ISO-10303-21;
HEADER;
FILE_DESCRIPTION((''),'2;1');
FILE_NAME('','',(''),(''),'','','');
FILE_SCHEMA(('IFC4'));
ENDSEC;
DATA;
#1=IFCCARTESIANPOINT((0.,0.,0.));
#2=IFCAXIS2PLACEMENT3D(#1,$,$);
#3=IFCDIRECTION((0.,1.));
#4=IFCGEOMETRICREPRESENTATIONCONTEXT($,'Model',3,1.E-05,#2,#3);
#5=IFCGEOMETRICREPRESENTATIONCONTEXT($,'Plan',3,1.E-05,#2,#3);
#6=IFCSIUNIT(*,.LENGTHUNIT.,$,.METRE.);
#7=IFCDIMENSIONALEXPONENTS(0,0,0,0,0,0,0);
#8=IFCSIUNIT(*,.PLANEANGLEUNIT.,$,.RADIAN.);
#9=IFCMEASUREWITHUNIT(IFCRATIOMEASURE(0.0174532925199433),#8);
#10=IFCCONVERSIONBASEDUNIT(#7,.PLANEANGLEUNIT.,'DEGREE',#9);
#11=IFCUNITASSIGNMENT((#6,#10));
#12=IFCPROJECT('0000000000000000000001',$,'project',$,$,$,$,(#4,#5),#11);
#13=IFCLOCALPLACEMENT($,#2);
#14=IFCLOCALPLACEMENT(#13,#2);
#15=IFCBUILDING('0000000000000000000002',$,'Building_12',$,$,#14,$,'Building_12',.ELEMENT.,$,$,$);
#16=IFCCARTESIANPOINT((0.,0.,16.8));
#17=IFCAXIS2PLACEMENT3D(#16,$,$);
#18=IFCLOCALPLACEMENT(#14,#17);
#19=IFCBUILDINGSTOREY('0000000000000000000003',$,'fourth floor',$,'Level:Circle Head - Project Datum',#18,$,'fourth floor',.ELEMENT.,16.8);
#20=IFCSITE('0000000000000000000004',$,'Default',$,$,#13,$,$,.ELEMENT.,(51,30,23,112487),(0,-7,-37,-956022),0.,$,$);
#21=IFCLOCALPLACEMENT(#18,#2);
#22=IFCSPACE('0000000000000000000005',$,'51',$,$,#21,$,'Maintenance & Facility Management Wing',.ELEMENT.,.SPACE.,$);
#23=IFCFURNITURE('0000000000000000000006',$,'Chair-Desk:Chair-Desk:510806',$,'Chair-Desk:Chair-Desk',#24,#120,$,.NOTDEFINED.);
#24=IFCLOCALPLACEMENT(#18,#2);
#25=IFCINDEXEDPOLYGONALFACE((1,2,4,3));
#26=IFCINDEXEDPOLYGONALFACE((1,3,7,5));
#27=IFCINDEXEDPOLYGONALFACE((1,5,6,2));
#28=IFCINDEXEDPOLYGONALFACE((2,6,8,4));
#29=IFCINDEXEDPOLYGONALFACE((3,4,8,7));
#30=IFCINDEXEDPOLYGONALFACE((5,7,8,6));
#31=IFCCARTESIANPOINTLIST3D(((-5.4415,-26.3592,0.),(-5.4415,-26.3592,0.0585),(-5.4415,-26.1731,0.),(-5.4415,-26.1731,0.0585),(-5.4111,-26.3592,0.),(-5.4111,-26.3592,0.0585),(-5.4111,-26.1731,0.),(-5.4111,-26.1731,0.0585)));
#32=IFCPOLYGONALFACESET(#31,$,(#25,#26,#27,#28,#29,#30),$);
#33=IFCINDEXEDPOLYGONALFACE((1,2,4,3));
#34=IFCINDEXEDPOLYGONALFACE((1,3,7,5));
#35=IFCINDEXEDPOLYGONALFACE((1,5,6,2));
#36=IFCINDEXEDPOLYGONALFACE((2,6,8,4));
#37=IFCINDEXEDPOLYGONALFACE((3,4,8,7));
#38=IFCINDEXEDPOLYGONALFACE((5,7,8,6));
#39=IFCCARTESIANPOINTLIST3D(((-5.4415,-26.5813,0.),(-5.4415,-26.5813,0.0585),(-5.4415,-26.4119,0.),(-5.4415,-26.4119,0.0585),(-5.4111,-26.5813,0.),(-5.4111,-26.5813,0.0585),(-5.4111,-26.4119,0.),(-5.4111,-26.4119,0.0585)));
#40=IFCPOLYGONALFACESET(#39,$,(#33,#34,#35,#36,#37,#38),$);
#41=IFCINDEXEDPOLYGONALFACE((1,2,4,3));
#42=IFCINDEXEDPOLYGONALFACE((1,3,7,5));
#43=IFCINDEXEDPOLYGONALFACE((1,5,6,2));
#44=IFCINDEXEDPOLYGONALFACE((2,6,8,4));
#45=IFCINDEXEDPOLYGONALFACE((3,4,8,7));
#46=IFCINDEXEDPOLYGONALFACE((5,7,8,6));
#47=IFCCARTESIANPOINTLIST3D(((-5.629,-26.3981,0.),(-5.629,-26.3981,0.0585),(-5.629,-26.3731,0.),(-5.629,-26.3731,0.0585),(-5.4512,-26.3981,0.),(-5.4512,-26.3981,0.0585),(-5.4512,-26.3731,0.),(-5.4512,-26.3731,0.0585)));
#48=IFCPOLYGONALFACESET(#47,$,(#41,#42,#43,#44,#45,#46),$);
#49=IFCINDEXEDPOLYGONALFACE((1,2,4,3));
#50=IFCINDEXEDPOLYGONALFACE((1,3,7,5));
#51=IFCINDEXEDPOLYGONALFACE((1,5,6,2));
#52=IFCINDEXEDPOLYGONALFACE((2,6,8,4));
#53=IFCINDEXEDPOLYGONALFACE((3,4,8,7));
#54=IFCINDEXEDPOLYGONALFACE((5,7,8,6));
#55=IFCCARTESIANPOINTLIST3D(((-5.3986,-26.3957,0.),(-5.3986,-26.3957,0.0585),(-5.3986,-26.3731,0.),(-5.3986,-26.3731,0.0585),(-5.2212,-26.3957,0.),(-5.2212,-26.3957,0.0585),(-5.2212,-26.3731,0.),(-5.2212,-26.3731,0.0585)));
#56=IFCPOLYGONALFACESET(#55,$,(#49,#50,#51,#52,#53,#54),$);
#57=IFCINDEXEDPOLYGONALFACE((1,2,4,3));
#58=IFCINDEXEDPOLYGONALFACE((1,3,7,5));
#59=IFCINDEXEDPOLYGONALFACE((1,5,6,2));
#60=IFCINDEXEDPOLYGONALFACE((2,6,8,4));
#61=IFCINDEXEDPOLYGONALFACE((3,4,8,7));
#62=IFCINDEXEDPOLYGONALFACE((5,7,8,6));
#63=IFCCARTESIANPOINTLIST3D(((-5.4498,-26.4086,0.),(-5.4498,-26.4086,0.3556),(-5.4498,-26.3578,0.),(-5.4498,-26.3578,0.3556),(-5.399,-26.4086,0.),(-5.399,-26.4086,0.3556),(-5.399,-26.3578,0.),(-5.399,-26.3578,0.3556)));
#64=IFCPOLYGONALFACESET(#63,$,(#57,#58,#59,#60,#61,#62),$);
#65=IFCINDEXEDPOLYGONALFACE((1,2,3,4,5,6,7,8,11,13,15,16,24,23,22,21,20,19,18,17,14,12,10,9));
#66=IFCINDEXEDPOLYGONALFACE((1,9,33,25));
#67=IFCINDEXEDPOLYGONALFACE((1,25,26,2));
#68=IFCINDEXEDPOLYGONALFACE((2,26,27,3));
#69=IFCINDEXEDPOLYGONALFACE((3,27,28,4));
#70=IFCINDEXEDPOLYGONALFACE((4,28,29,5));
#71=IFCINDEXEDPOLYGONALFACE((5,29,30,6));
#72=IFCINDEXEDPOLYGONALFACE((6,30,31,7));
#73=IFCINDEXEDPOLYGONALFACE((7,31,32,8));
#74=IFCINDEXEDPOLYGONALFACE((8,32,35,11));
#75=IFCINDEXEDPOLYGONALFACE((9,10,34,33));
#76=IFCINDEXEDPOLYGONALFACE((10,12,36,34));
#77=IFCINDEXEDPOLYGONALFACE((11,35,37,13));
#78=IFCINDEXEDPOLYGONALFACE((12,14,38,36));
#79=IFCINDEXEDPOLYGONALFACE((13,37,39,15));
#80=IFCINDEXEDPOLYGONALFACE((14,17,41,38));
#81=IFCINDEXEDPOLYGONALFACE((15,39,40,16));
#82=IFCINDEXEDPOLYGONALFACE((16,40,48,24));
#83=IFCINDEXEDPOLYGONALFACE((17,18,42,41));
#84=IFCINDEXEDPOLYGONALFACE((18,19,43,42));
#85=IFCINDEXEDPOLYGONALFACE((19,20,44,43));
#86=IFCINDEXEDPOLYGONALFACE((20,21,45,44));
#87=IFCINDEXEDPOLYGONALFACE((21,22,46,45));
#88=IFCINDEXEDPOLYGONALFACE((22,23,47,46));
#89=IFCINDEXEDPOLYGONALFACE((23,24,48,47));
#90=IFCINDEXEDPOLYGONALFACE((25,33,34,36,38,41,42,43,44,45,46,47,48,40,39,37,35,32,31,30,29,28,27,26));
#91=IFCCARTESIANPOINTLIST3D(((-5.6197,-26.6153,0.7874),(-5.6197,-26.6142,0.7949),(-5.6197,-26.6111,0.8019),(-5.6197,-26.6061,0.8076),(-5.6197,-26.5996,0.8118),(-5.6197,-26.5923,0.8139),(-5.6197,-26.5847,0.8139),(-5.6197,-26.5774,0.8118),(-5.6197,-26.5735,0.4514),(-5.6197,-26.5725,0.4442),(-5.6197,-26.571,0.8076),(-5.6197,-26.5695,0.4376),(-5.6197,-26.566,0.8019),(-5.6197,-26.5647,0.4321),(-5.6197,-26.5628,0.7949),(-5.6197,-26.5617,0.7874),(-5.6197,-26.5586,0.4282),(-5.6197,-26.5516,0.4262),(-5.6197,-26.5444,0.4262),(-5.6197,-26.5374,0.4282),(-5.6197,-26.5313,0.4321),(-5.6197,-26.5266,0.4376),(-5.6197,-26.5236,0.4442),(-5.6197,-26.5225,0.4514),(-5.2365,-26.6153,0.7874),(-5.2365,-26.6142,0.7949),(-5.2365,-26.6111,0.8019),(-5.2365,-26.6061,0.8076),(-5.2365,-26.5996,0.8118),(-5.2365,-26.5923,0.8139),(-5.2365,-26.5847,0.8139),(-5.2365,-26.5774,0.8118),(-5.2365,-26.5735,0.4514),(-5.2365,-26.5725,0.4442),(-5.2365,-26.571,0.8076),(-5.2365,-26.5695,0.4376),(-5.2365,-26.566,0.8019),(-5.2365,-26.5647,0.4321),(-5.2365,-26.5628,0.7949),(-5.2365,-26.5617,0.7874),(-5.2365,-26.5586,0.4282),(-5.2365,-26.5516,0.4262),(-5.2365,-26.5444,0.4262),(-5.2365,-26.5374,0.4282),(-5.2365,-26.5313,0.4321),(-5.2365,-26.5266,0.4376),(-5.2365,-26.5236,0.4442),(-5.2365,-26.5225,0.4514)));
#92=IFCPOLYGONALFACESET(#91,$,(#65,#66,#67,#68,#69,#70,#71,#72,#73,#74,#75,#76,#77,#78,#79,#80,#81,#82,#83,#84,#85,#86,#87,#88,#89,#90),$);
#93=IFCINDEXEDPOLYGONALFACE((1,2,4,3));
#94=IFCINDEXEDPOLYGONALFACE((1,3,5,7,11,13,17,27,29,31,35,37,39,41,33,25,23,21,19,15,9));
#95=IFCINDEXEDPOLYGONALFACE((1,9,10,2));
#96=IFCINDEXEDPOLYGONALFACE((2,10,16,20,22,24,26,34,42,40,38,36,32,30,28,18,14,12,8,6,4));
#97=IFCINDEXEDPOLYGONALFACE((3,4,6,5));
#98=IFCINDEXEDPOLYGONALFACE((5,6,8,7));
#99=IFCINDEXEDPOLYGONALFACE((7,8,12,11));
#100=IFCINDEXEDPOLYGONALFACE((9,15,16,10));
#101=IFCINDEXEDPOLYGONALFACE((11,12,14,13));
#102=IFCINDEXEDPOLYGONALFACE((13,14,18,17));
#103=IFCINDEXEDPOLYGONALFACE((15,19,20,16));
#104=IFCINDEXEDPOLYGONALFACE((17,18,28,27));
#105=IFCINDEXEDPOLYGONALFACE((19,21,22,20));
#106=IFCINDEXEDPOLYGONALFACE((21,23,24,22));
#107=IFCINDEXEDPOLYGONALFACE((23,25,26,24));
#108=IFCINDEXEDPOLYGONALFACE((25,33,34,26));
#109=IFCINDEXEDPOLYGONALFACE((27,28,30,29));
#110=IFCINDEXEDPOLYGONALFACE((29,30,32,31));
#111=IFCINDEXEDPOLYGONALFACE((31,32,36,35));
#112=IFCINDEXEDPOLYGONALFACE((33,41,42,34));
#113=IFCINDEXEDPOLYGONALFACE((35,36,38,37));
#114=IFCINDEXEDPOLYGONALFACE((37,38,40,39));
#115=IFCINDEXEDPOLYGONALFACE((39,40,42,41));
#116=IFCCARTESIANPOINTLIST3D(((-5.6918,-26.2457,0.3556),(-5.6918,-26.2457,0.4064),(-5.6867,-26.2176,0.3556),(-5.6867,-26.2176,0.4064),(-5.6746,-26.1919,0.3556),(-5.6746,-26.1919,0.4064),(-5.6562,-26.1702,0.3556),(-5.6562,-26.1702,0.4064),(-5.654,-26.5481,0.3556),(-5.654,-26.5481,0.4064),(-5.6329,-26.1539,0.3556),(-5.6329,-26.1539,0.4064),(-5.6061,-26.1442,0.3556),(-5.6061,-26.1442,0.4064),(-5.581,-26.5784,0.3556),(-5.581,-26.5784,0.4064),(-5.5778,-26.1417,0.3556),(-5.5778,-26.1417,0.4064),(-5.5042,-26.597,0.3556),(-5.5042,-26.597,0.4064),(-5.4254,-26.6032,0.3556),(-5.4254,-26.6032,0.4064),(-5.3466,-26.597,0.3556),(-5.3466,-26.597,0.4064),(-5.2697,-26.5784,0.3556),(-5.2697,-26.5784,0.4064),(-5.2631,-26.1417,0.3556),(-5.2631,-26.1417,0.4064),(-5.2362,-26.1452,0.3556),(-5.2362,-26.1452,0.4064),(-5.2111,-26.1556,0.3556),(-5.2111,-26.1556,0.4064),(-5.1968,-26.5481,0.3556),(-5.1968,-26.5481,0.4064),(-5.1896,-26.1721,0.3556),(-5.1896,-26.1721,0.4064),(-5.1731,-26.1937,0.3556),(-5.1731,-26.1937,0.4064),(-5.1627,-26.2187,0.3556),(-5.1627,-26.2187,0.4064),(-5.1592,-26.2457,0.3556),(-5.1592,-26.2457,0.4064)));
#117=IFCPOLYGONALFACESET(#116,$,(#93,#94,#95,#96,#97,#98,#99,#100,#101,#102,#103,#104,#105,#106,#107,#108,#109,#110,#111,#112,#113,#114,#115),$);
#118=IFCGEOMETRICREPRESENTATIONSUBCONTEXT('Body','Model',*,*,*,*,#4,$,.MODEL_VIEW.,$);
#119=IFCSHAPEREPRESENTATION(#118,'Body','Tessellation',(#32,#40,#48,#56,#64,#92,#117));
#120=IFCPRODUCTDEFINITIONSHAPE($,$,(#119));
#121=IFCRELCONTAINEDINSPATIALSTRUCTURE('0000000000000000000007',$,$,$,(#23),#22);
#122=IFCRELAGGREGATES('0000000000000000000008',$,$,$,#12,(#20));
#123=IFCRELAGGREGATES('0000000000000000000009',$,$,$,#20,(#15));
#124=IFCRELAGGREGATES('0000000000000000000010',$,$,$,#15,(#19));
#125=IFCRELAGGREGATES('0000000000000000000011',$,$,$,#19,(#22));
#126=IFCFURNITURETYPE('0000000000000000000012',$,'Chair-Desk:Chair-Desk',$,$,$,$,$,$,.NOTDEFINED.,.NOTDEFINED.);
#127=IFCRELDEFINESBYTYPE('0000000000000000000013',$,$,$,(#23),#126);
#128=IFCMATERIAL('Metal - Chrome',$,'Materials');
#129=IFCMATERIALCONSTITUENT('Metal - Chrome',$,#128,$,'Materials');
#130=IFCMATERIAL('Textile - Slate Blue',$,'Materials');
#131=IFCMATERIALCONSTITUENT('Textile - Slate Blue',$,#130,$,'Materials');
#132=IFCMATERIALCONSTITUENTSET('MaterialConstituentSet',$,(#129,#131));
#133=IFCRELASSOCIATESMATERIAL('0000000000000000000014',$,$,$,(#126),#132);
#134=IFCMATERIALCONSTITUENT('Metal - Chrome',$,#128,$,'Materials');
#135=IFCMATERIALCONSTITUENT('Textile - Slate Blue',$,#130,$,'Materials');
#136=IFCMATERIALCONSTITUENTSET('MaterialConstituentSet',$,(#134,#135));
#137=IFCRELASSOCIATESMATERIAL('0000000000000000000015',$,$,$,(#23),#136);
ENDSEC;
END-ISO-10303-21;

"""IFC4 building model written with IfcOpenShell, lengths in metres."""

from ifc_helpers import new_model, entity, si_unit, converted_unit, direction, frame, origin, place, context, subcontext, project, spatial, line, arc, indexed_curve, outline, extrude, source, transform, mapped, material, constituent, constituent_set, type_object, type_shapes, element, save


model = new_model("IFC4")

# Units and contexts
model_context = context("Model", 3, precision=1e-05, world=origin(), true_north=direction((0.0, 1.0)))
plan_context = context("Plan", 3, precision=1e-05, world=origin(), true_north=direction((0.0, 1.0)))
body_context = subcontext(model_context, "Body", "Model", "MODEL_VIEW")
ifc_project = project(units=[si_unit("LENGTHUNIT", "METRE"), converted_unit("PLANEANGLEUNIT", "DEGREE", entity("IfcRatioMeasure", 0.0174532925199433), si_unit("PLANEANGLEUNIT", "RADIAN"), dimensions=[0, 0, 0, 0, 0, 0, 0])], contexts=[model_context, plan_context])

# Site, building, storey
site_placement = place(None, origin())
site = spatial("IfcSite", under=ifc_project, at=site_placement, Name="Default", CompositionType="ELEMENT", RefLatitude=(51, 30, 23, 112487), RefLongitude=(0, -7, -37, -956022), RefElevation=0.0)
building_placement = place(site_placement, origin())
building = spatial("IfcBuilding", under=site, at=building_placement, Name="Building_12", LongName="Building_12", CompositionType="ELEMENT")
storey_placement = place(building_placement, frame((0.0, 0.0, 16.8)))
storey = spatial("IfcBuildingStorey", under=building, at=storey_placement, Name="fourth floor", ObjectType="Level:Circle Head - Project Datum", LongName="fourth floor", CompositionType="ELEMENT", Elevation=16.8)

# Shared definitions
space_placement = place(storey_placement, origin())
space = spatial("IfcSpace", under=storey, at=space_placement, Name="51", LongName="Maintenance & Facility Management Wing", CompositionType="ELEMENT", PredefinedType="SPACE")

# Furniture
ifc_material_1 = material(Name="Metal - Chrome", Category="Materials")
ifc_constituent_1 = constituent(ifc_material_1, Name="Metal - Chrome", Category="Materials")
ifc_material_2 = material(Name="Textile - Slate Blue", Category="Materials")
ifc_constituent_2 = constituent(ifc_material_2, Name="Textile - Slate Blue", Category="Materials")
ifc_constituent_set_1 = constituent_set(constituents=[ifc_constituent_1, ifc_constituent_2], Name="MaterialConstituentSet")
ifc_constituent_3 = constituent(ifc_material_1, Name="Metal - Chrome", Category="Materials")
ifc_constituent_4 = constituent(ifc_material_2, Name="Textile - Slate Blue", Category="Materials")
ifc_constituent_set_2 = constituent_set(constituents=[ifc_constituent_3, ifc_constituent_4], Name="MaterialConstituentSet")
furniture_type = type_object("IfcFurnitureType", Name="Chair-Desk:Chair-Desk", AssemblyPlace="NOTDEFINED", PredefinedType="NOTDEFINED", material=ifc_constituent_set_2)
shared_shape = source(origin(), body_context, "Body", "SweptSolid", [
    extrude(outline(indexed_curve([(-0.0152, -0.093), (0.0152, -0.093), (0.0152, 0.093), (-0.0152, 0.093), (-0.0152, -0.093)], self_intersect=False)), frame((-0.0009, 0.2819, 0.0)), (0.0, 0.0, 1.0), 0.0585),
    extrude(outline(indexed_curve([(-0.0152, -0.0847), (0.0152, -0.0847), (0.0152, 0.0847), (-0.0152, 0.0847), (-0.0152, -0.0847)], self_intersect=False)), frame((-0.0009, 0.0515, 0.0), z_axis=(0.0, 0.0, 1.0), x_axis=(-1.0, 0.0, 0.0)), (0.0, 0.0, 1.0), 0.0585),
    extrude(outline(indexed_curve([(-0.0125, -0.0889), (0.0125, -0.0889), (0.0125, 0.0889), (-0.0125, 0.0889), (-0.0125, -0.0889)], self_intersect=False)), frame((-0.1148, 0.1625, 0.0), z_axis=(0.0, 0.0, 1.0), x_axis=(0.0, -1.0, 0.0)), (0.0, 0.0, 1.0), 0.0585),
    extrude(outline(indexed_curve([(-0.0887, -0.0113), (0.0887, -0.0113), (0.0887, 0.0113), (-0.0887, 0.0113), (-0.0887, -0.0113)], self_intersect=False)), frame((0.1155, 0.1637, 0.0), z_axis=(0.0, 0.0, 1.0), x_axis=(-1.0, 0.0, 0.0)), (0.0, 0.0, 1.0), 0.0585),
    extrude(outline(indexed_curve([(-0.0254, -0.0254), (0.0254, -0.0254), (0.0254, 0.0254), (-0.0254, 0.0254), (-0.0254, -0.0254)], self_intersect=False)), frame((0.0009, 0.1649, 0.0), z_axis=(0.0, 0.0, 1.0), x_axis=(-1.0, 0.0, 0.0)), (0.0, 0.0, 1.0), 0.3556),
    extrude(outline(indexed_curve([(0.0065, 0.168), (-0.0202, 0.1948), (-0.047, 0.168), (-0.0052, -0.168), (0.0202, -0.1935), (0.0457, -0.168)], segments=[arc(1, 2, 3), line(3, 4), arc(4, 5, 6), line(6, 1)], self_intersect=False)), frame((-0.1944, -0.0202, 0.6194), z_axis=(1.0, 0.0, 0.0), x_axis=(0.0, 1.0, 0.0)), (0.0, 0.0, 1.0), 0.3833),
    extrude(outline(indexed_curve([(-0.0989, -0.2577), (0.2059, -0.2577), (0.2889, -0.0377), (0.2626, 0.1959), (-0.0328, 0.2708), (-0.1095, 0.2497), (-0.1489, 0.1805), (-0.1879, -0.1317), (-0.1694, -0.2131)], segments=[line(1, 2), arc(2, 3, 4), line(4, 5), arc(5, 6, 7), line(7, 8), arc(8, 9, 1)], self_intersect=False)), frame((0.0016, 0.2363, 0.3556), z_axis=(0.0, 0.0, 1.0), x_axis=(0.124035, -0.992278, 0.0)), (0.0, 0.0, 1.0), 0.0508),
])
type_shapes(furniture_type, [shared_shape])
furniture_1_placement = place(space_placement, frame((-5.4254, -26.5481, 0.0)))
element("IfcFurniture", 1, at=furniture_1_placement, inside=space, type_object=furniture_type, material=ifc_constituent_set_1, Name="Chair-Desk:Chair-Desk:510806", ObjectType="Chair-Desk:Chair-Desk", PredefinedType="NOTDEFINED", context=body_context, shape_type="MappedRepresentation", body=[
    mapped(shared_shape, transform((0.0, 0.0, 0.0), scale=1.0)),
])

save(model, "model.ifc")
